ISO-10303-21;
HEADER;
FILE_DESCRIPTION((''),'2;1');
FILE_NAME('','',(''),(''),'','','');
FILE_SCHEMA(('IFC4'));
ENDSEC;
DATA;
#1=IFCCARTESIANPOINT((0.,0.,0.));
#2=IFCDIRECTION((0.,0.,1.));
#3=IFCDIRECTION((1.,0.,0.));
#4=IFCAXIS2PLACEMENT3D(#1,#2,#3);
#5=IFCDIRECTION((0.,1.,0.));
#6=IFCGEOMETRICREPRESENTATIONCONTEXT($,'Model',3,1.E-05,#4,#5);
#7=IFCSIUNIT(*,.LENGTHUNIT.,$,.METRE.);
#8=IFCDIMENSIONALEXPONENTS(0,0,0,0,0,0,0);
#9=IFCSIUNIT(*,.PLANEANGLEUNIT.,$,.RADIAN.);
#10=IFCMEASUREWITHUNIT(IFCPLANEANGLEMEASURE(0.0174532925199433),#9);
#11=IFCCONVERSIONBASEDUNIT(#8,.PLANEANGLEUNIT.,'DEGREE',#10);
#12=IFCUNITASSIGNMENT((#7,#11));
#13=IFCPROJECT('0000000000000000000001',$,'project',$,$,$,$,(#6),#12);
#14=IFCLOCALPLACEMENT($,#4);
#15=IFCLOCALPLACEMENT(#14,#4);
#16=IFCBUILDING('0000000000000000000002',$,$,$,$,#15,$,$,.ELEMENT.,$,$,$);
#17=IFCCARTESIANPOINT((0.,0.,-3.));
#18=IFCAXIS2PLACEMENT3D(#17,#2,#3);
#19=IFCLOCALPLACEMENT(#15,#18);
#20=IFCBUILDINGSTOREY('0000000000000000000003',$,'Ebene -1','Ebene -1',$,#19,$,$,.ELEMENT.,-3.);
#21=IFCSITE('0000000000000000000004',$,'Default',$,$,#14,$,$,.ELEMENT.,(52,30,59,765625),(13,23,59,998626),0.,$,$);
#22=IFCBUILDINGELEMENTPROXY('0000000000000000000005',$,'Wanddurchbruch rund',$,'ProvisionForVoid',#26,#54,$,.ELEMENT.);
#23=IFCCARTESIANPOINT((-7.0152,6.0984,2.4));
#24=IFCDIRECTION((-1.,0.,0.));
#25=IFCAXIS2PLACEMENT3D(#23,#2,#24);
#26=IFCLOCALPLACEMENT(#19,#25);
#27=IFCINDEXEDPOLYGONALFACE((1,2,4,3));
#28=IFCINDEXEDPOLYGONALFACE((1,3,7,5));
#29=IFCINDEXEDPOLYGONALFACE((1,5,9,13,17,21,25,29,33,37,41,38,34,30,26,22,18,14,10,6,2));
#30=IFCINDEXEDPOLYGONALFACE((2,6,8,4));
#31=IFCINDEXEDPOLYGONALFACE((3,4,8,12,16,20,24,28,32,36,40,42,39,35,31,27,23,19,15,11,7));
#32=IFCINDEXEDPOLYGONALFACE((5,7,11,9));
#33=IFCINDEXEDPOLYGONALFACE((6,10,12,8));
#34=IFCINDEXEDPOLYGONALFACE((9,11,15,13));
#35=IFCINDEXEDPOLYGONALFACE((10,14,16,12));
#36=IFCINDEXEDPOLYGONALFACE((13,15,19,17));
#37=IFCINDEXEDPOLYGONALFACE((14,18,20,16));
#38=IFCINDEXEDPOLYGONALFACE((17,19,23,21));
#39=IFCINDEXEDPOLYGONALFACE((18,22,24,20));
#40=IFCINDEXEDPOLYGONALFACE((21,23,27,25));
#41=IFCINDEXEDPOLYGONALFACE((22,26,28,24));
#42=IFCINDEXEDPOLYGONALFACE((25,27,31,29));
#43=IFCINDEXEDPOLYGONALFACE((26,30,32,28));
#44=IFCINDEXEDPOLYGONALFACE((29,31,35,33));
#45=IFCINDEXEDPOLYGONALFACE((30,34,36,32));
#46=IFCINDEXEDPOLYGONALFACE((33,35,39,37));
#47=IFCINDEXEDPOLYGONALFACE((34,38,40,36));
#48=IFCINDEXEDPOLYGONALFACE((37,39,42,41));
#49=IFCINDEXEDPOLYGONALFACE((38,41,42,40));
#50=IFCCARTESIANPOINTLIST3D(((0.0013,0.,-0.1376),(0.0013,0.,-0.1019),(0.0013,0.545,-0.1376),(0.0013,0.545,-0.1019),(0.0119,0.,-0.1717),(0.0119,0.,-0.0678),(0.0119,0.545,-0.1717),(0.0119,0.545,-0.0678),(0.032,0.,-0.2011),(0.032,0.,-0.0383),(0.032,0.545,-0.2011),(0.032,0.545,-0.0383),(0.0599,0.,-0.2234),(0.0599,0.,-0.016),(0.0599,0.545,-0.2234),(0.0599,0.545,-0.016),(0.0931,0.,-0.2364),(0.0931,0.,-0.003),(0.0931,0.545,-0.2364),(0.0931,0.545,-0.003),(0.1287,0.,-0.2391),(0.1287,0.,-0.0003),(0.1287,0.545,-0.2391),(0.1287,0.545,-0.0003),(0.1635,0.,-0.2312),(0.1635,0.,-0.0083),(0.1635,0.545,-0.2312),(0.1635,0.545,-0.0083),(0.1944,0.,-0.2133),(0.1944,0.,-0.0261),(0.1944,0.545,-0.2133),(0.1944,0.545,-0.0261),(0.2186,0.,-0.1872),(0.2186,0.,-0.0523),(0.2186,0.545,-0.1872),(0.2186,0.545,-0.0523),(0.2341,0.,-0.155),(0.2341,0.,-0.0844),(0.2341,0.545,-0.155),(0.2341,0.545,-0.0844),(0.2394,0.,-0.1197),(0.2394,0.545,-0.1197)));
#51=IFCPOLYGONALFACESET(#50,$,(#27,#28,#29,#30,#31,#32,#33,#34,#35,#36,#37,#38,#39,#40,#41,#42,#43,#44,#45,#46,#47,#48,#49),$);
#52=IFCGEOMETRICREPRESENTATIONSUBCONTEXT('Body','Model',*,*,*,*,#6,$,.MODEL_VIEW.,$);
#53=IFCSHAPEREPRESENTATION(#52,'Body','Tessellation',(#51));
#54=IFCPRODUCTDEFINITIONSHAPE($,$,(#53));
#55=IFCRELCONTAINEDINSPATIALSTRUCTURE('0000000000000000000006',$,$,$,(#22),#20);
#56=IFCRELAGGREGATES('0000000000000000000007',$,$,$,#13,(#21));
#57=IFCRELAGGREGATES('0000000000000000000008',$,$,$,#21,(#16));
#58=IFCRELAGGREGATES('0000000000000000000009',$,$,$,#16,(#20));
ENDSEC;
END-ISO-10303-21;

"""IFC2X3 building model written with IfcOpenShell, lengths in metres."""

from ifc_helpers import new_model, entity, si_unit, converted_unit, direction, frame, origin_with_axes, origin_2d_with_axis, place, context, subcontext, project, spatial, circle, extrude, source, transform, mapped, element, save


model = new_model("IFC2X3")

# Units and contexts
model_context = context("Model", 3, precision=1e-05, world=origin_with_axes(), true_north=direction((0.0, 1.0, 0.0)))
body_context = subcontext(model_context, "Body", "Model", "MODEL_VIEW")
ifc_project = project(units=[si_unit("LENGTHUNIT", "METRE"), converted_unit("PLANEANGLEUNIT", "DEGREE", entity("IfcPlaneAngleMeasure", 0.0174532925199433), si_unit("PLANEANGLEUNIT", "RADIAN"), dimensions=[0, 0, 0, 0, 0, 0, 0])], contexts=[model_context])

# Site, building, storey
site_placement = place(None, origin_with_axes())
site = spatial("IfcSite", under=ifc_project, at=site_placement, Name="Default", CompositionType="ELEMENT", RefLatitude=(52, 30, 59, 765625), RefLongitude=(13, 23, 59, 998626), RefElevation=0.0)
building_placement = place(site_placement, origin_with_axes())
building = spatial("IfcBuilding", under=site, at=building_placement, CompositionType="ELEMENT")
storey_placement = place(building_placement, frame((0.0, 0.0, -3.0), z_axis=(0.0, 0.0, 1.0), x_axis=(1.0, 0.0, 0.0)))
storey = spatial("IfcBuildingStorey", under=building, at=storey_placement, Name="Ebene -1", Description="Ebene -1", CompositionType="ELEMENT", Elevation=-3.0)

# Building element proxy
shared_shape = source(origin_with_axes(), body_context, "Body", "SweptSolid", [
    extrude(circle(Radius=0.1197, at=origin_2d_with_axis()), frame((0.1197, 0.0, -0.1197), z_axis=(0.0, -1.0, 0.0), x_axis=(1.0, 0.0, 0.0)), (0.0, 0.0, -1.0), 0.545),
])
proxy_placement = place(storey_placement, frame((-7.0152, 6.0984, 2.4), z_axis=(0.0, 0.0, 1.0), x_axis=(-1.0, 0.0, 0.0)))
element("IfcBuildingElementProxy", 1, at=proxy_placement, inside=storey, Name="Wanddurchbruch rund", ObjectType="ProvisionForVoid", CompositionType="ELEMENT", context=body_context, shape_type="MappedRepresentation", body=[
    mapped(shared_shape, transform((0.0, 0.0, 0.0), x_axis=(1.0, 0.0, 0.0), y_axis=(0.0, 1.0, 0.0), z_axis=(0.0, 0.0, 1.0), scale=1.0)),
])

save(model, "model.ifc")
